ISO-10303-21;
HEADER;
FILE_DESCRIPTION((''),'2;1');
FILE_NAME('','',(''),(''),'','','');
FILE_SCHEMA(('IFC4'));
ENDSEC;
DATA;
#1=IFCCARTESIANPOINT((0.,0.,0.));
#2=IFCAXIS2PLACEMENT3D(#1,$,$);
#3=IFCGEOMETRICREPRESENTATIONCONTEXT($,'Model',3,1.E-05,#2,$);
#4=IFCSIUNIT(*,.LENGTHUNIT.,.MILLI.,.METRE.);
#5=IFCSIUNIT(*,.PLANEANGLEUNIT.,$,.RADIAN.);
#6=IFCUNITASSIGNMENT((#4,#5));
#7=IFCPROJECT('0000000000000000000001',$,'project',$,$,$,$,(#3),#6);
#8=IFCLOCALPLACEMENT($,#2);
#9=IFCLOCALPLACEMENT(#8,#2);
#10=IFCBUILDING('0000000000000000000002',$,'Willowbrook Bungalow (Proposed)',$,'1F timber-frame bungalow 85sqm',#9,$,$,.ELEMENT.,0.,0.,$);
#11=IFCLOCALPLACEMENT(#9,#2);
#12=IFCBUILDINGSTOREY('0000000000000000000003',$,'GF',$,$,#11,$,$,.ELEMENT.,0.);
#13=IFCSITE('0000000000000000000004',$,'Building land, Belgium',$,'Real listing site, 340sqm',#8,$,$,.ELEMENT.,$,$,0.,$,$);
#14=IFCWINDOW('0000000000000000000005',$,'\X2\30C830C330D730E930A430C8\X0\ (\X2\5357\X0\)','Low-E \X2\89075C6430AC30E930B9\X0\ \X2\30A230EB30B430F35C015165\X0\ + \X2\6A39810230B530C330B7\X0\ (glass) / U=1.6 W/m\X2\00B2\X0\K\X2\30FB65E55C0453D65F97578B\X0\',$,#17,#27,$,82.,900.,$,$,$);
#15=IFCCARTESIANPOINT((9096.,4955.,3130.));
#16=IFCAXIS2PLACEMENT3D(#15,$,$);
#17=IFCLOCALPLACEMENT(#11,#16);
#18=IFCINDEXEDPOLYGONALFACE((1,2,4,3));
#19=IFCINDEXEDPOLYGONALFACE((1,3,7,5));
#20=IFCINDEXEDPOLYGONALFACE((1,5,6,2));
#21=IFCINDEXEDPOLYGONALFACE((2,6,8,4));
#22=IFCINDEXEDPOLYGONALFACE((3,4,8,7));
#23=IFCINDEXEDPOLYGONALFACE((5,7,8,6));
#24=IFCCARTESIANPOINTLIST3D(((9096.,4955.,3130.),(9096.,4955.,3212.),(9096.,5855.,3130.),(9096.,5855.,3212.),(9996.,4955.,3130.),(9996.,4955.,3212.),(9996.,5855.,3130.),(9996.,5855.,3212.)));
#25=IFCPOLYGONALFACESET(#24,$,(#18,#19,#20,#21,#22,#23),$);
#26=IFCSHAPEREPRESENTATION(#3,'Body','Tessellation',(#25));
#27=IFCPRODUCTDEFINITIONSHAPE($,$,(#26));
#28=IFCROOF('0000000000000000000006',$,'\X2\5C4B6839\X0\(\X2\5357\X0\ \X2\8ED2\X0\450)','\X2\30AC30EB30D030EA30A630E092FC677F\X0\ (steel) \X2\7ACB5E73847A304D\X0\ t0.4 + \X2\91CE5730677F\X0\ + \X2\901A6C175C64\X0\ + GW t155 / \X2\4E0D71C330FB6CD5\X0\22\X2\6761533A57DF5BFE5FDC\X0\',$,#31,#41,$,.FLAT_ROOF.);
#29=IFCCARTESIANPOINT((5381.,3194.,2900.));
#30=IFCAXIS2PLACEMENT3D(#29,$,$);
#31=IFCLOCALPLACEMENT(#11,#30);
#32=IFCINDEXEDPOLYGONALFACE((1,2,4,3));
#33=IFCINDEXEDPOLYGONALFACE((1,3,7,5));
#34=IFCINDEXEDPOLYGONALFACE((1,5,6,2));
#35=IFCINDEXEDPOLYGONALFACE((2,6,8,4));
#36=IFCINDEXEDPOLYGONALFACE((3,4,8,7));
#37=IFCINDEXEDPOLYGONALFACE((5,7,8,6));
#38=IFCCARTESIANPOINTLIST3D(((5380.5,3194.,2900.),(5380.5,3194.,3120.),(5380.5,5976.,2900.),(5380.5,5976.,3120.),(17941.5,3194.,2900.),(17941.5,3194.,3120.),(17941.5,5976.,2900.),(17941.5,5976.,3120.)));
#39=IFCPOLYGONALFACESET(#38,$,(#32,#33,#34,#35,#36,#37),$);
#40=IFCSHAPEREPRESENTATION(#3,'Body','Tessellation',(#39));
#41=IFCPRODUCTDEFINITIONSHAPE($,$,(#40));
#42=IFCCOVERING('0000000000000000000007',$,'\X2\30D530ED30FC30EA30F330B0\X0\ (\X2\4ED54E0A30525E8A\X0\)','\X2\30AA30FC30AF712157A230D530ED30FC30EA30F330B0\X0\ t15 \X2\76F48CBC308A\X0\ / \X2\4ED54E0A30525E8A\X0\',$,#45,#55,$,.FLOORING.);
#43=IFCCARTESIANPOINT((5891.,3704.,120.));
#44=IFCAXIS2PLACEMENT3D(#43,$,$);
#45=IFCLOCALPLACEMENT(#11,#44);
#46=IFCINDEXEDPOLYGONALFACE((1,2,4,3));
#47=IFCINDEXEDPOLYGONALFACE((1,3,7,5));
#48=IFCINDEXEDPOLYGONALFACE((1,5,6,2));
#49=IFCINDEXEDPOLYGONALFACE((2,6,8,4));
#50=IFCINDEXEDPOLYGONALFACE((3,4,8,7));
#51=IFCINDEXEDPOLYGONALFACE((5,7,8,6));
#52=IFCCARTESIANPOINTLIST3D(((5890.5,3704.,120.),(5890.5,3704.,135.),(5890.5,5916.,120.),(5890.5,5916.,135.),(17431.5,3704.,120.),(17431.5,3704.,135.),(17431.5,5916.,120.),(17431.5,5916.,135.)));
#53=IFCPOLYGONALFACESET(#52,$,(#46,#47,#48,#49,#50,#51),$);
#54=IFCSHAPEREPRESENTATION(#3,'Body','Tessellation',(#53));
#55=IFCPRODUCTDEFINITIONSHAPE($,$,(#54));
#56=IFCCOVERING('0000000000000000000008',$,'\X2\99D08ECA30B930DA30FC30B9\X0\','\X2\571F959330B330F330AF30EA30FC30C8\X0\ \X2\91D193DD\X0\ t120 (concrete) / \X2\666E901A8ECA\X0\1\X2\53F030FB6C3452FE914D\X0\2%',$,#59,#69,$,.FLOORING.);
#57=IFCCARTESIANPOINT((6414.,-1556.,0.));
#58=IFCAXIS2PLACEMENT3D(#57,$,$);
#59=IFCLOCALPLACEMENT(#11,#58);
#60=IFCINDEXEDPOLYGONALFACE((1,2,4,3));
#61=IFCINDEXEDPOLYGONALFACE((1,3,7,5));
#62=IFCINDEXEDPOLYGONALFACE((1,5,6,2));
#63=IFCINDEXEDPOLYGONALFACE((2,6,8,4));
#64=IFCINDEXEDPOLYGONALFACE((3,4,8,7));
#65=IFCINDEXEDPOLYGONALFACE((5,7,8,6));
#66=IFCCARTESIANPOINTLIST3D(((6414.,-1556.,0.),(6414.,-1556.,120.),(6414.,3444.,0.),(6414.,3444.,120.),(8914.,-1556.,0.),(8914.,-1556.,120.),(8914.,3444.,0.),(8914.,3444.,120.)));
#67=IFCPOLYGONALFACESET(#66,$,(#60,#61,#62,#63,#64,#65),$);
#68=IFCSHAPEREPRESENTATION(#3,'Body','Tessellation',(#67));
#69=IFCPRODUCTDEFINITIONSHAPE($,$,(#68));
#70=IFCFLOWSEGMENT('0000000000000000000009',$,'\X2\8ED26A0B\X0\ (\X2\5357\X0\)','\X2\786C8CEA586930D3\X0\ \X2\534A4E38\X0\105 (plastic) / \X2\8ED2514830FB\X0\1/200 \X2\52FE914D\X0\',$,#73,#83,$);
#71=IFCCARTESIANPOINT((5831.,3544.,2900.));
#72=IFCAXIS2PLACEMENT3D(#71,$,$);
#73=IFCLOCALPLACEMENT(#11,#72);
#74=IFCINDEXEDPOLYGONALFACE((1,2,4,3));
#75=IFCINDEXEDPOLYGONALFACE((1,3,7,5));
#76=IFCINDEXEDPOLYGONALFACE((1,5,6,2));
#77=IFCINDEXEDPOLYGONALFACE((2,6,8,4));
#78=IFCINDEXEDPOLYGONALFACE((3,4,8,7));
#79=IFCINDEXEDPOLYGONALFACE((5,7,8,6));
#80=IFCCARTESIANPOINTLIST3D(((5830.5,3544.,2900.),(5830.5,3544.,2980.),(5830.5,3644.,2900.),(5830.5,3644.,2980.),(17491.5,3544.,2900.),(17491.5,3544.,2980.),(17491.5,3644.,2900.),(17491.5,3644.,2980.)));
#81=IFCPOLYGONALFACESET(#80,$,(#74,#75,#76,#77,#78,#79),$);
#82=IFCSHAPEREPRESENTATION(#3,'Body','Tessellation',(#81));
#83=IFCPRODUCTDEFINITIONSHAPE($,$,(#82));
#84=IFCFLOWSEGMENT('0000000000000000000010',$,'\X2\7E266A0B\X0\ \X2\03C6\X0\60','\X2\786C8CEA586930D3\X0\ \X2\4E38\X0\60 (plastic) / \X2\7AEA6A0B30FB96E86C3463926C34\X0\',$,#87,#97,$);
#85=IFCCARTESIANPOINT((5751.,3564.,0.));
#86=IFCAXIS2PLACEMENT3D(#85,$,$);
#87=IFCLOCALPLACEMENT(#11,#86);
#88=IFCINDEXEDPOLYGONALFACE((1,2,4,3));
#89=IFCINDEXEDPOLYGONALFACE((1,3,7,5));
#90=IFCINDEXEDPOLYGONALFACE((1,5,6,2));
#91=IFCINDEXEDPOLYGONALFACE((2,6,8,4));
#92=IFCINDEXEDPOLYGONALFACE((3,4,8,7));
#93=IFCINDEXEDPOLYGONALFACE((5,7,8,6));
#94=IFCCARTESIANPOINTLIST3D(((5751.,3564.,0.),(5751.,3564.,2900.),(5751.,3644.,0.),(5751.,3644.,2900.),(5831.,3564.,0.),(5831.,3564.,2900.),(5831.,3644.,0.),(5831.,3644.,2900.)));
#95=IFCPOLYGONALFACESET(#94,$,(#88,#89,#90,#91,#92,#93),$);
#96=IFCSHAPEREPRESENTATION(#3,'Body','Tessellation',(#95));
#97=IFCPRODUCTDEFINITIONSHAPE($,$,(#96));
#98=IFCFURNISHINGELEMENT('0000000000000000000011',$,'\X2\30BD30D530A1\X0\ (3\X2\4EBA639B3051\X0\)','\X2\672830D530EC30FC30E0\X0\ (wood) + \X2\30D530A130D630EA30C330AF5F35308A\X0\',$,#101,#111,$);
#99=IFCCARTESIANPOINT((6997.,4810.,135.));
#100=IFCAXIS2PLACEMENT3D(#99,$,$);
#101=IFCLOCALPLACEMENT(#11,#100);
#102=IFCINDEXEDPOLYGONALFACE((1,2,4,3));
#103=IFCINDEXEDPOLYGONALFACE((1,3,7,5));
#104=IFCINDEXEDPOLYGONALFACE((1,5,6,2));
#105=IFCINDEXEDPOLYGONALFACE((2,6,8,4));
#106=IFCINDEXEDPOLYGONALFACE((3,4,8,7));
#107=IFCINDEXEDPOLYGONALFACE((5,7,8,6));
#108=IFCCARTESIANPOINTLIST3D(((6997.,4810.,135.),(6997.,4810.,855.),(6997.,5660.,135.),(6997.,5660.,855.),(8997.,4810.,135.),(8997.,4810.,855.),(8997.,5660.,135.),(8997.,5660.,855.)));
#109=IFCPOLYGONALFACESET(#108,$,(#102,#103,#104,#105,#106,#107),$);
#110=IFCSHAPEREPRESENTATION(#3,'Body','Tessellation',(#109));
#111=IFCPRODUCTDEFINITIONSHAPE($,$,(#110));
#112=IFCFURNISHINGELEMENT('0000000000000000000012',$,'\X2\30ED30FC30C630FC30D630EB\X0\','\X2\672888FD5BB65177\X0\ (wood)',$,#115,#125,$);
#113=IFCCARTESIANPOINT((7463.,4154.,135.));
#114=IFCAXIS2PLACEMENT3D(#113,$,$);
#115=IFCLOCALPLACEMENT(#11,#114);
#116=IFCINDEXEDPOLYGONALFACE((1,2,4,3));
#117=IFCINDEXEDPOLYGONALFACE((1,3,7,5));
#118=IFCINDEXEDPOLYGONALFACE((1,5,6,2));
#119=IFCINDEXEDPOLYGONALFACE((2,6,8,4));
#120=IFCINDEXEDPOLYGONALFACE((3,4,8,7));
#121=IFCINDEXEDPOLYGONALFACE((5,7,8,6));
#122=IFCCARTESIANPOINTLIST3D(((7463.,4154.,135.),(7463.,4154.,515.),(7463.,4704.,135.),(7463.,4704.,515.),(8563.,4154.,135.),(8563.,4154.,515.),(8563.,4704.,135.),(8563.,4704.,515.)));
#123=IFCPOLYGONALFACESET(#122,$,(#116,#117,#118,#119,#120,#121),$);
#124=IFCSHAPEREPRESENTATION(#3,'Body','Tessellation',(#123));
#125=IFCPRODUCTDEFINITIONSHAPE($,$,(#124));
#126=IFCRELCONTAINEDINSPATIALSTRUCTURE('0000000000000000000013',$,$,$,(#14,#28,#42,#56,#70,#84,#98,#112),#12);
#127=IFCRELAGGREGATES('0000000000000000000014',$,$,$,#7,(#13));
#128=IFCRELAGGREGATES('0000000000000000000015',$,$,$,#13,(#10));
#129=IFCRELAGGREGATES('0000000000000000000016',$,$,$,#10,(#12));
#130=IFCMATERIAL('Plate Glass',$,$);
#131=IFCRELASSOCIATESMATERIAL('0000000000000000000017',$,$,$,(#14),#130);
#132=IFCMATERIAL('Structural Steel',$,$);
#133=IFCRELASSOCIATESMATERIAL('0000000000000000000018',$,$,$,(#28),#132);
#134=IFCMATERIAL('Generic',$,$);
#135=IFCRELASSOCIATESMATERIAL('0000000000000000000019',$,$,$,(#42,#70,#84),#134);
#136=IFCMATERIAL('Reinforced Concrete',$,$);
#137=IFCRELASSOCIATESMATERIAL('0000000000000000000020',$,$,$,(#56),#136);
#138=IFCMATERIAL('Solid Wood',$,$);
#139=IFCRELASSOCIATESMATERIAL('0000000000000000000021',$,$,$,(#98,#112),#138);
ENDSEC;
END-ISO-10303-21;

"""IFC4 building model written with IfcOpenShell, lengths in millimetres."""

from ifc_helpers import new_model, si_unit, frame, frame_2d, origin, place, context, project, spatial, rectangle, extrude, material, element, save


model = new_model("IFC4")

# Units and contexts
model_context = context("Model", 3, precision=1e-05, world=origin())
ifc_project = project(units=[si_unit("LENGTHUNIT", "METRE", prefix="MILLI"), si_unit("PLANEANGLEUNIT", "RADIAN")], contexts=[model_context])

# Site, building, storey
site_placement = place(None, origin())
site = spatial("IfcSite", under=ifc_project, at=site_placement, Name="Building land, Belgium", ObjectType="Real listing site, 340sqm", CompositionType="ELEMENT", RefElevation=0.0)
building_placement = place(site_placement, origin())
building = spatial("IfcBuilding", under=site, at=building_placement, Name="Willowbrook Bungalow (Proposed)", ObjectType="1F timber-frame bungalow 85sqm", CompositionType="ELEMENT", ElevationOfRefHeight=0.0, ElevationOfTerrain=0.0)
storey_placement = place(building_placement, origin())
storey = spatial("IfcBuildingStorey", under=building, at=storey_placement, Name="GF", CompositionType="ELEMENT", Elevation=0.0)

# Shared definitions
ifc_material_1 = material(Name="Solid Wood")

# Shared definitions
ifc_material_2 = material(Name="Reinforced Concrete")

# Shared definitions
ifc_material_3 = material(Name="Plate Glass")

# Window
window_1_placement = place(storey_placement, frame((9096.0, 4955.0, 3130.0)))
element("IfcWindow", 1, at=window_1_placement, inside=storey, material=ifc_material_3, Name="トップライト (南)", Description="Low-E 複層ガラス アルゴン封入 + 樹脂サッシ (glass) / U=1.6 W/m²K・日射取得型", OverallHeight=82.0, OverallWidth=900.0, context=model_context, shape_type="SweptSolid", body=[
    extrude(rectangle(XDim=900.0, YDim=900.0, at=frame_2d((450.0, 450.0))), frame((9096.0, 4955.0, 3130.0)), (0.0, 0.0, 1.0), 82.0),
])

# Roof
ifc_material_4 = material(Name="Structural Steel")
roof_1_placement = place(storey_placement, frame((5381.0, 3194.0, 2900.0)))
element("IfcRoof", 2, at=roof_1_placement, inside=storey, material=ifc_material_4, Name="屋根(南 軒450)", Description="ガルバリウム鋼板 (steel) 立平葺き t0.4 + 野地板 + 通気層 + GW t155 / 不燃・法22条区域対応", PredefinedType="FLAT_ROOF", context=model_context, shape_type="SweptSolid", body=[
    extrude(rectangle(XDim=12561.0, YDim=2782.0, at=frame_2d((6280.0, 1391.0))), frame((5381.0, 3194.0, 2900.0)), (0.0, 0.0, 1.0), 220.0),
])

# Coverings
ifc_material_5 = material(Name="Generic")
covering_1_placement = place(storey_placement, frame((5891.0, 3704.0, 120.0)))
element("IfcCovering", 3, at=covering_1_placement, inside=storey, material=ifc_material_5, Name="フローリング (仕上げ床)", Description="オーク無垢フローリング t15 直貼り / 仕上げ床", PredefinedType="FLOORING", context=model_context, shape_type="SweptSolid", body=[
    extrude(rectangle(XDim=11541.0, YDim=2212.0, at=frame_2d((5770.0, 1106.0))), frame((5891.0, 3704.0, 120.0)), (0.0, 0.0, 1.0), 15.0),
])
covering_2_placement = place(storey_placement, frame((6414.0, -1556.0, 0.0)))
element("IfcCovering", 4, at=covering_2_placement, inside=storey, material=ifc_material_2, Name="駐車スペース", Description="土間コンクリート 金鏝 t120 (concrete) / 普通車1台・水勾配2%", PredefinedType="FLOORING", context=model_context, shape_type="SweptSolid", body=[
    extrude(rectangle(XDim=2500.0, YDim=5000.0, at=frame_2d((1250.0, 2500.0))), frame((6414.0, -1556.0, 0.0)), (0.0, 0.0, 1.0), 120.0),
])

# Flow segments
flow_segment_1_placement = place(storey_placement, frame((5831.0, 3544.0, 2900.0)))
element("IfcFlowSegment", 5, at=flow_segment_1_placement, inside=storey, material=ifc_material_5, Name="軒樋 (南)", Description="硬質塩ビ 半丸105 (plastic) / 軒先・1/200 勾配", context=model_context, shape_type="SweptSolid", body=[
    extrude(rectangle(XDim=11661.0, YDim=100.0, at=frame_2d((5830.0, 50.0))), frame((5831.0, 3544.0, 2900.0)), (0.0, 0.0, 1.0), 80.0),
])
flow_segment_2_placement = place(storey_placement, frame((5751.0, 3564.0, 0.0)))
element("IfcFlowSegment", 6, at=flow_segment_2_placement, inside=storey, material=ifc_material_5, Name="縦樋 φ60", Description="硬質塩ビ 丸60 (plastic) / 竪樋・雨水排水", context=model_context, shape_type="SweptSolid", body=[
    extrude(rectangle(XDim=80.0, YDim=80.0, at=frame_2d((40.0, 40.0))), frame((5751.0, 3564.0, 0.0)), (0.0, 0.0, 1.0), 2900.0),
])

# Furnishing elements
furnishing_1_placement = place(storey_placement, frame((6997.0, 4810.0, 135.0)))
element("IfcFurnishingElement", 7, at=furnishing_1_placement, inside=storey, material=ifc_material_1, Name="ソファ (3人掛け)", Description="木フレーム (wood) + ファブリック張り", context=model_context, shape_type="SweptSolid", body=[
    extrude(rectangle(XDim=2000.0, YDim=850.0, at=frame_2d((1000.0, 425.0))), frame((6997.0, 4810.0, 135.0)), (0.0, 0.0, 1.0), 720.0),
])
furnishing_2_placement = place(storey_placement, frame((7463.0, 4154.0, 135.0)))
element("IfcFurnishingElement", 8, at=furnishing_2_placement, inside=storey, material=ifc_material_1, Name="ローテーブル", Description="木製家具 (wood)", context=model_context, shape_type="SweptSolid", body=[
    extrude(rectangle(XDim=1100.0, YDim=550.0, at=frame_2d((550.0, 275.0))), frame((7463.0, 4154.0, 135.0)), (0.0, 0.0, 1.0), 380.0),
])

save(model, "model.ifc")
